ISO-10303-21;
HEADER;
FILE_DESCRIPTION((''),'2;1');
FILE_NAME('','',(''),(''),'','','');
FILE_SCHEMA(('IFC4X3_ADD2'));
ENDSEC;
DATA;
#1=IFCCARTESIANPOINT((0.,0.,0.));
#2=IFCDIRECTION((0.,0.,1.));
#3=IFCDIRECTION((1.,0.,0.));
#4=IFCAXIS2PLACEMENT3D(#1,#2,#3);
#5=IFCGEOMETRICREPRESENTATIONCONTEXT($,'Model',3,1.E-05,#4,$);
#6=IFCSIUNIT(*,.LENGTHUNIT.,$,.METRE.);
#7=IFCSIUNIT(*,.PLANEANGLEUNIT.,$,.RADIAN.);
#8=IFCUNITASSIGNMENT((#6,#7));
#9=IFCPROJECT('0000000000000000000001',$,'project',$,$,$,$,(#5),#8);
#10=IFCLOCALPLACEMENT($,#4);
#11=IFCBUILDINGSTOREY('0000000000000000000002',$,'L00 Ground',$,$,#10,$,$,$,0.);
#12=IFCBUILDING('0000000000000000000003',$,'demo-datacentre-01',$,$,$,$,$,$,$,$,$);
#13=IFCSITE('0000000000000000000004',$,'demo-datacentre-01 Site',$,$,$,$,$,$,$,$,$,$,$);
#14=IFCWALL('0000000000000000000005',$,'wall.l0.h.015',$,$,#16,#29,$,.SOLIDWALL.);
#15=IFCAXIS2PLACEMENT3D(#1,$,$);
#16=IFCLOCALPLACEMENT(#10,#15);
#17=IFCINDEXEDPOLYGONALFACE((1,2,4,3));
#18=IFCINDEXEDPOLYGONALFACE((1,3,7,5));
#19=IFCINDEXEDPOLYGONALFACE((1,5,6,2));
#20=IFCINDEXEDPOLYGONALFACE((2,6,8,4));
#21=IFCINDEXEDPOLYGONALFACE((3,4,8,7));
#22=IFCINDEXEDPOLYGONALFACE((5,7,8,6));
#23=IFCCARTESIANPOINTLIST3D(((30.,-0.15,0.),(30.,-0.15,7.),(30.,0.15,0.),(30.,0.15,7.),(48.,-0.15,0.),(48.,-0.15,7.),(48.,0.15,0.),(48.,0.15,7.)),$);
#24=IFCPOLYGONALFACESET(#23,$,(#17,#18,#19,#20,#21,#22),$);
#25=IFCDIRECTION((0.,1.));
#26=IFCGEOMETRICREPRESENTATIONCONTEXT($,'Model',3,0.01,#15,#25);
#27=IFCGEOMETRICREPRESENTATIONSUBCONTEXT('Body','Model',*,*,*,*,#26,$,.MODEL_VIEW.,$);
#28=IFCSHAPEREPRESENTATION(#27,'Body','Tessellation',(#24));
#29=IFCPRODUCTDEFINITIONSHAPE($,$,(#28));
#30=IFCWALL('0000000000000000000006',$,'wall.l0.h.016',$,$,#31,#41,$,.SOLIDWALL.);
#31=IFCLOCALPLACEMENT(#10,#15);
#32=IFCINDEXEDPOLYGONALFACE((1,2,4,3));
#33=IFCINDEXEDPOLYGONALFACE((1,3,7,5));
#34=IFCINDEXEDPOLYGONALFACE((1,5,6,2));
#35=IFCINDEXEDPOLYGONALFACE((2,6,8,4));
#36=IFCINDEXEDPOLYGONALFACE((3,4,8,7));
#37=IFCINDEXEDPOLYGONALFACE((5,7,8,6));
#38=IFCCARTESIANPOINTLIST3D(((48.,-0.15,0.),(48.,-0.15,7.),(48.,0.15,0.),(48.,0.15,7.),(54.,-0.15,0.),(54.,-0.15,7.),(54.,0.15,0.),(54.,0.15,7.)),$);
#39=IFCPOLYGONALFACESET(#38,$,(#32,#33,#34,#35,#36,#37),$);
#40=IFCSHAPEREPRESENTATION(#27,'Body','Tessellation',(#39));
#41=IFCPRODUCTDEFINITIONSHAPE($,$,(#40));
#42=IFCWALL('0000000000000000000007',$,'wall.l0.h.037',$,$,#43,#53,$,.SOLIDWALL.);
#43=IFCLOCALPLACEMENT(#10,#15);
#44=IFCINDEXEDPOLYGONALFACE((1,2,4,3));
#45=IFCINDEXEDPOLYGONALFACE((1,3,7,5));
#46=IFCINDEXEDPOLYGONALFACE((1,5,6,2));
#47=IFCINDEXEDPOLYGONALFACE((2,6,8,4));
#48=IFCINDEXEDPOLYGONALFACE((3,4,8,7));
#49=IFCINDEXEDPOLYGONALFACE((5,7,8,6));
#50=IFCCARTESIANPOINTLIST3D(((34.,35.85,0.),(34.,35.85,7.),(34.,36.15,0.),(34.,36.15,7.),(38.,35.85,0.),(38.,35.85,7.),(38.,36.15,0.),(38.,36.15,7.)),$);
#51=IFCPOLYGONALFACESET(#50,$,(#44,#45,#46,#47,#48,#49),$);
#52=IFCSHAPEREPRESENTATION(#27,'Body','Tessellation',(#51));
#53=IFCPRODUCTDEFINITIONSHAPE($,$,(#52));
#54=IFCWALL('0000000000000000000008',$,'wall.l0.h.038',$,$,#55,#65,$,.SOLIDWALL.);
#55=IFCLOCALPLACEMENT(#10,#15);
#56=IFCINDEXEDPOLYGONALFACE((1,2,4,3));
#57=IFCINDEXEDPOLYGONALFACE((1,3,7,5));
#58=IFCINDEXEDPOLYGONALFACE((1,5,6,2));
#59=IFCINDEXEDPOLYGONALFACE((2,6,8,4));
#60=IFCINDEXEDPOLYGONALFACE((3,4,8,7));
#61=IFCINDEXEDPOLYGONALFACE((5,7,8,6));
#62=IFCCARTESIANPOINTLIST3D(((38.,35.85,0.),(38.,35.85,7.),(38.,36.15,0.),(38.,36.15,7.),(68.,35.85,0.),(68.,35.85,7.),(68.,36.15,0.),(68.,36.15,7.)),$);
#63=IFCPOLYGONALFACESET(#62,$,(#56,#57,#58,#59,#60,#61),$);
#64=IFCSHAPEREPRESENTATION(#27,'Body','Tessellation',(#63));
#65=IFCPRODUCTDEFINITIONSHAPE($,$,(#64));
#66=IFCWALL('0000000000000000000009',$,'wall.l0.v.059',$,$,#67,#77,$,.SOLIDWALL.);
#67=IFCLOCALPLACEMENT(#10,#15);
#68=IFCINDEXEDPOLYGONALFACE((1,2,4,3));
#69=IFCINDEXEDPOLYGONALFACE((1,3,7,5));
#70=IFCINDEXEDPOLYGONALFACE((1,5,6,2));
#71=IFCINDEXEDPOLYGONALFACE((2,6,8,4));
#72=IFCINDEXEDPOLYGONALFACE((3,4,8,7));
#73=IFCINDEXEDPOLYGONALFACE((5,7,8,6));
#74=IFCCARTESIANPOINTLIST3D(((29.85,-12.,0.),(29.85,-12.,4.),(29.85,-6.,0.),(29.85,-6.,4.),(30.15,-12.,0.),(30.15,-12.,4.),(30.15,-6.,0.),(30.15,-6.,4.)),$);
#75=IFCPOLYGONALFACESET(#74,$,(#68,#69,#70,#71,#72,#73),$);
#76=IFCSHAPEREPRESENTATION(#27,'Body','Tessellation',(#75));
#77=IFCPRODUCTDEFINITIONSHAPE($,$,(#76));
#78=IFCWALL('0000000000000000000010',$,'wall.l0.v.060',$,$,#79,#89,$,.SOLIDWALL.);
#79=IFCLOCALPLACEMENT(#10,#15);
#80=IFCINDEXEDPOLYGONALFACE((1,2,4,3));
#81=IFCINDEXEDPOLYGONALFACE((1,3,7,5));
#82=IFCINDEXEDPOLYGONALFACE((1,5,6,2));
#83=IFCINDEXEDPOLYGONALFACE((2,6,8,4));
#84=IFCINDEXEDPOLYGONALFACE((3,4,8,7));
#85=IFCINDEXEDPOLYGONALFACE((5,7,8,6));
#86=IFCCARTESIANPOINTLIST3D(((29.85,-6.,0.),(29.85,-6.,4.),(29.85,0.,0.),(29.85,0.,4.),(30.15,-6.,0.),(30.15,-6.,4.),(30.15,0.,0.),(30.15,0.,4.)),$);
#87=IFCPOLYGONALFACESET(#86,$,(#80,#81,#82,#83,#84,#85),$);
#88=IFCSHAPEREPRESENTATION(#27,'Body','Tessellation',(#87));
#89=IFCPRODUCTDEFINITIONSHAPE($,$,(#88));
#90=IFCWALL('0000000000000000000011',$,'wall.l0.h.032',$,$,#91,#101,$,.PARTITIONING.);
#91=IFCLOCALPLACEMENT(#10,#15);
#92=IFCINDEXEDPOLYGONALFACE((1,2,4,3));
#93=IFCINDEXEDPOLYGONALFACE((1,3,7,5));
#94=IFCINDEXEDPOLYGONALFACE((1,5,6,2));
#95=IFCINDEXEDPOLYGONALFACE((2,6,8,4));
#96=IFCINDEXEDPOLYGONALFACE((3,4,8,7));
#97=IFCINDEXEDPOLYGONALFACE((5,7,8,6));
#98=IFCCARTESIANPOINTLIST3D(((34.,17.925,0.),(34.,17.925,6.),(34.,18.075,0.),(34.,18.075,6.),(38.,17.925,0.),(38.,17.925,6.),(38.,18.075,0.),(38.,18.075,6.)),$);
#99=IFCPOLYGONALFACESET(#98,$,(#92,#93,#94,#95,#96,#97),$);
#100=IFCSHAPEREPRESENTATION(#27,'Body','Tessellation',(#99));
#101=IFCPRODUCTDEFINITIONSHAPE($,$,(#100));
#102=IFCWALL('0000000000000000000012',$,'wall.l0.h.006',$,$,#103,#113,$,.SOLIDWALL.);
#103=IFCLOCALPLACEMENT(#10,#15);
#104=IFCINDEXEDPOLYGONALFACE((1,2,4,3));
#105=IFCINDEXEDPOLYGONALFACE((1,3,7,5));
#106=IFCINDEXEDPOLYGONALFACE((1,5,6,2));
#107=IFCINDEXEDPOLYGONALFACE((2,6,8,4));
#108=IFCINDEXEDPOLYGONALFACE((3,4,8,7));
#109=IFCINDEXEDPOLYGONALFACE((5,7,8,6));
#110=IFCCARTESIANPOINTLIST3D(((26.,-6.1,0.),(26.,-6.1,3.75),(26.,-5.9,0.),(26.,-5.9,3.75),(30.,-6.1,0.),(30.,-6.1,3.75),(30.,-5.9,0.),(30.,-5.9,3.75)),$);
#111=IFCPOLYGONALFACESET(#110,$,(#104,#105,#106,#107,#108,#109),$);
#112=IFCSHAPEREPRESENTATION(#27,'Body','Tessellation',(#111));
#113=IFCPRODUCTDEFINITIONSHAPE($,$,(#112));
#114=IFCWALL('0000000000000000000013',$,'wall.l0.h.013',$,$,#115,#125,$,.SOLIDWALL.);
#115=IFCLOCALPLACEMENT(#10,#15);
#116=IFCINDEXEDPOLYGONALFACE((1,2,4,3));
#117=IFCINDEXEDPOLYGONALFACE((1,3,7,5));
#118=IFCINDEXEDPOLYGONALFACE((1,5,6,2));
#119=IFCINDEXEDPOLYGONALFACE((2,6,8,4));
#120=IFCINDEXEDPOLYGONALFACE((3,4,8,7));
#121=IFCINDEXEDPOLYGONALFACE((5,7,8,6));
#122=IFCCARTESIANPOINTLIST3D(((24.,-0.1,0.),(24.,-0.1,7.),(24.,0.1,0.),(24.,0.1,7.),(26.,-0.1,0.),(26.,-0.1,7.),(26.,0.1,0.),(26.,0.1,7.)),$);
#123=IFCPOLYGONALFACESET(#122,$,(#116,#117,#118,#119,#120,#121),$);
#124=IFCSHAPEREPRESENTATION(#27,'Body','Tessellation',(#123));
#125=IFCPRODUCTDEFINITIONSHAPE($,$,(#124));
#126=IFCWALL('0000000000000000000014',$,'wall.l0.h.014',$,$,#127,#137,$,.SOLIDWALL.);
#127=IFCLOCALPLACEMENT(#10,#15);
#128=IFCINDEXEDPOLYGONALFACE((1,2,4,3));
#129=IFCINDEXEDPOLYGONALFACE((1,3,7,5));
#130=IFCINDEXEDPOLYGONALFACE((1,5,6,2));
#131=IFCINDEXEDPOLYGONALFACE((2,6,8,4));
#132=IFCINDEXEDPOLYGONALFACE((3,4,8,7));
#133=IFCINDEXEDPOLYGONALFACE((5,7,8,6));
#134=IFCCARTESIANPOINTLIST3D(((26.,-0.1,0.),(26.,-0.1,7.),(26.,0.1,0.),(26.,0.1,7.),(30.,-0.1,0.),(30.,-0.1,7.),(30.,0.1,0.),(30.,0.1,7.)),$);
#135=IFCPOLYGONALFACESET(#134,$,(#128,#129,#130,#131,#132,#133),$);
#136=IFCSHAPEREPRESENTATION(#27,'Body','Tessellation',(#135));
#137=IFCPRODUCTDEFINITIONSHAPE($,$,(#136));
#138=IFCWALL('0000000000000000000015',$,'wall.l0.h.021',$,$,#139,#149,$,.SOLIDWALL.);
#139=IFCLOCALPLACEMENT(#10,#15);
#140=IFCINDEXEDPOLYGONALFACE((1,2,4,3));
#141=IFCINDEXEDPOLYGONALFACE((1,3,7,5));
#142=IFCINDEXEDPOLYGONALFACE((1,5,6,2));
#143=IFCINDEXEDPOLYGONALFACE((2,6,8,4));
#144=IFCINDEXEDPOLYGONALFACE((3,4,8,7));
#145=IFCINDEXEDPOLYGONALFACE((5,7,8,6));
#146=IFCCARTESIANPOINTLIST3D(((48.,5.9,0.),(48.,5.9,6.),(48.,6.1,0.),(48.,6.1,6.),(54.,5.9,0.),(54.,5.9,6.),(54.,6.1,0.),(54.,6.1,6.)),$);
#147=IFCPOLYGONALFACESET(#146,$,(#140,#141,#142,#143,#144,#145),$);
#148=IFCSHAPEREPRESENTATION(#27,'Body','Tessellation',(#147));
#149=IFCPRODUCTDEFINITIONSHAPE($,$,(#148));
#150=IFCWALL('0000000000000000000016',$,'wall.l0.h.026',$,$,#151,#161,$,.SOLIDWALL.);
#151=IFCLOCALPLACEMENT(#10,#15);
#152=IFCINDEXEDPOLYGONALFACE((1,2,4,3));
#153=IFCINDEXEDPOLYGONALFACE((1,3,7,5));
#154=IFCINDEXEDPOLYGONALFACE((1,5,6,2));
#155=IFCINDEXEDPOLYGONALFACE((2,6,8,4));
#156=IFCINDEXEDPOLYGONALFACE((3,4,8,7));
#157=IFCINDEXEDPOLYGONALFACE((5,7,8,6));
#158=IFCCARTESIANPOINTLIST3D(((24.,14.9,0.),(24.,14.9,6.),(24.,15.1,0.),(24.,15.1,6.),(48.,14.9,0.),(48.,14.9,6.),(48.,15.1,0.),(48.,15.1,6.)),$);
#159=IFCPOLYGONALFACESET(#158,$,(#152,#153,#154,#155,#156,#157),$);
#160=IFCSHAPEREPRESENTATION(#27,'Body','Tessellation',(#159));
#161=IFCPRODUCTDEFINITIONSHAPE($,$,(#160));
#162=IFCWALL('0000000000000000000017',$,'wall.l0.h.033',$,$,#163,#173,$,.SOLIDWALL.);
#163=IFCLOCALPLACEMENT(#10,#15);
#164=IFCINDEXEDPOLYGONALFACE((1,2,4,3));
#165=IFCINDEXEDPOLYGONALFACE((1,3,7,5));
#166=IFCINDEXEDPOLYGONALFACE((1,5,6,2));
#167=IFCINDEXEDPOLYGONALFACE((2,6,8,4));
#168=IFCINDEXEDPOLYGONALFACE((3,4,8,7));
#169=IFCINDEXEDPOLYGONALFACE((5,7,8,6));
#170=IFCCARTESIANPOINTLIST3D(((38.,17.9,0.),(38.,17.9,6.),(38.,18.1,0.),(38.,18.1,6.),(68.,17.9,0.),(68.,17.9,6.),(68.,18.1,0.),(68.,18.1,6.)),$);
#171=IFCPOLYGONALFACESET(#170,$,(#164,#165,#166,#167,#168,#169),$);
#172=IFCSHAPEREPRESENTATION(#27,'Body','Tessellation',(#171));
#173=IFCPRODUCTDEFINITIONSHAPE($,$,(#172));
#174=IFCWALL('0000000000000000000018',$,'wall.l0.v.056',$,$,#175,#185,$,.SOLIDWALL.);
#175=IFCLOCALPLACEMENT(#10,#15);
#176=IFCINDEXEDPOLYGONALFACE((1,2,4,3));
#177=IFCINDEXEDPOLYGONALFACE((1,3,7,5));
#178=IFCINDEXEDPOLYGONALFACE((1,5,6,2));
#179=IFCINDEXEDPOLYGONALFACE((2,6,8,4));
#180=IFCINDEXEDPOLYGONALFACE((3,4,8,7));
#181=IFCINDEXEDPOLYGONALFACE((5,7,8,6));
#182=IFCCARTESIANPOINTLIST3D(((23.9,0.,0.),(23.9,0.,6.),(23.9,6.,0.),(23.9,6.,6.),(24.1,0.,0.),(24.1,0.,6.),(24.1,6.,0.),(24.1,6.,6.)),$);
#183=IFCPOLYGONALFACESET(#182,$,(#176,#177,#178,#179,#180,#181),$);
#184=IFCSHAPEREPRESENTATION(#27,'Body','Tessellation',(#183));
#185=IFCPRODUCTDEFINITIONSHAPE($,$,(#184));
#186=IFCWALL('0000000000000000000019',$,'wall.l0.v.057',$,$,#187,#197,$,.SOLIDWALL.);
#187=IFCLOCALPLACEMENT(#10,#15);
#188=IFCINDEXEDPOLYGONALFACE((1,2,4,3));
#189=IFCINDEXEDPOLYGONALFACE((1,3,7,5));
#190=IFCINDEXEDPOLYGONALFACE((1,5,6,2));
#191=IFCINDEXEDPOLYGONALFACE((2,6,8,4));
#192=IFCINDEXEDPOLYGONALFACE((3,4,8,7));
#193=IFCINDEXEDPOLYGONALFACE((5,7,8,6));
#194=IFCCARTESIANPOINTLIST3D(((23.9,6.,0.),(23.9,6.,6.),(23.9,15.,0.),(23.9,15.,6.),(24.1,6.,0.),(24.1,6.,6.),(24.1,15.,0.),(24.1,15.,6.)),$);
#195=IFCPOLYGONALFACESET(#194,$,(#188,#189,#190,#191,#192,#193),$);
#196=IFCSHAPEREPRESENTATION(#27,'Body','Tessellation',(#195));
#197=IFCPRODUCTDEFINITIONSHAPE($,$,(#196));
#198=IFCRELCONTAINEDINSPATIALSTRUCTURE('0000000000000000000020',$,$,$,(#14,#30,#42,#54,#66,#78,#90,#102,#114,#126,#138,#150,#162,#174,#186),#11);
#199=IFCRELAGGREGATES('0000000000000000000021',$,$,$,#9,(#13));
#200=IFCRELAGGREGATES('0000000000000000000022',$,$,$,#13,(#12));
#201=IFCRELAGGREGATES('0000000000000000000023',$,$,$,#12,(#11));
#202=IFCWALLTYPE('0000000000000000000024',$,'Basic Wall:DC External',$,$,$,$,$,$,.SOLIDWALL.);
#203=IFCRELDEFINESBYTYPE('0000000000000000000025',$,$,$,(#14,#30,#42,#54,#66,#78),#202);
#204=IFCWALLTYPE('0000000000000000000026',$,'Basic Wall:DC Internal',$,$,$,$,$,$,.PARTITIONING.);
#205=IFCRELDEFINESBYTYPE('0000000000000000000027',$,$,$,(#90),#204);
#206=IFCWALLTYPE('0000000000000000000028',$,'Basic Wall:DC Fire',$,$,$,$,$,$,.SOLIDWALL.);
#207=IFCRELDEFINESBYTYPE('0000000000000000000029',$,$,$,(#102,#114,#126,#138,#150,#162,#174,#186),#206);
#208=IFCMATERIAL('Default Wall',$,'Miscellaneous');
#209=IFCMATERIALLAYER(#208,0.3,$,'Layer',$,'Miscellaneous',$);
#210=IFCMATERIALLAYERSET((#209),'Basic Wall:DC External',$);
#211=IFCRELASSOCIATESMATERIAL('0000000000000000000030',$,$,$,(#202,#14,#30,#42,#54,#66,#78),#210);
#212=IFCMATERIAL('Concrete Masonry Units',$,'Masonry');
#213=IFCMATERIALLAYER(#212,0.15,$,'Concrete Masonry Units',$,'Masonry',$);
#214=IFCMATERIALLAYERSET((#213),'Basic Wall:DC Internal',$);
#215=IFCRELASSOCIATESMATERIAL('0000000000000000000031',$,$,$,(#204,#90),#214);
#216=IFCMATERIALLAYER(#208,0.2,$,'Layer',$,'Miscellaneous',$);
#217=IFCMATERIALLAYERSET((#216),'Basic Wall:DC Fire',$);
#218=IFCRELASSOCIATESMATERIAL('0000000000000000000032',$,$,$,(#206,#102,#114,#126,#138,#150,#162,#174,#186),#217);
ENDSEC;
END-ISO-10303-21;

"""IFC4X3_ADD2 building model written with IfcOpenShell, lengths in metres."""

from ifc_helpers import new_model, si_unit, direction, frame, frame_2d, origin, origin_with_axes, place, context, subcontext, project, spatial, rectangle, extrude, material, layer, layer_set, type_object, element, save


model = new_model("IFC4X3_ADD2")

# Units and contexts
model_context_1 = context("Model", 3, precision=0.01, world=origin(), true_north=direction((0.0, 1.0)))
model_context_2 = context("Model", 3, precision=1e-05, world=origin_with_axes())
body_context = subcontext(model_context_1, "Body", "Model", "MODEL_VIEW")
ifc_project = project(units=[si_unit("LENGTHUNIT", "METRE"), si_unit("PLANEANGLEUNIT", "RADIAN")], contexts=[model_context_2])

# Site, building, storey
site = spatial("IfcSite", under=ifc_project, Name="demo-datacentre-01 Site")
building = spatial("IfcBuilding", under=site, Name="demo-datacentre-01")
storey_placement = place(None, origin_with_axes())
storey = spatial("IfcBuildingStorey", under=building, at=storey_placement, Name="L00 Ground", Elevation=0.0)

# Walls
ifc_material_1 = material(Name="Default Wall", Category="Miscellaneous")
ifc_layer_1 = layer(ifc_material_1, 0.3, Name="Layer", Category="Miscellaneous")
ifc_layer_set_1 = layer_set([ifc_layer_1], Name="Basic Wall:DC External")
wall_type_1 = type_object("IfcWallType", Name="Basic Wall:DC External", PredefinedType="SOLIDWALL", material=ifc_layer_set_1)
placement_1 = place(None, origin())
placement_2 = place(placement_1, origin())
placement_3 = place(placement_2, origin())
wall_1_placement = place(placement_3, frame((30.0, 0.0, 0.0)))
element("IfcWall", 1, at=wall_1_placement, inside=storey, type_object=wall_type_1, material=ifc_layer_set_1, Name="wall.l0.h.015", PredefinedType="SOLIDWALL", context=body_context, shape_type="SweptSolid", body=[
    extrude(rectangle(XDim=18.0, YDim=0.3, at=frame_2d((9.0, 0.0), x_axis=(-1.0, 0.0))), origin(), (0.0, 0.0, 1.0), 7.0),
])
wall_2_placement = place(placement_3, frame((48.0, 0.0, 0.0)))
element("IfcWall", 2, at=wall_2_placement, inside=storey, type_object=wall_type_1, material=ifc_layer_set_1, Name="wall.l0.h.016", PredefinedType="SOLIDWALL", context=body_context, shape_type="SweptSolid", body=[
    extrude(rectangle(XDim=6.0, YDim=0.3, at=frame_2d((3.0, 0.0), x_axis=(-1.0, 0.0))), origin(), (0.0, 0.0, 1.0), 7.0),
])
wall_3_placement = place(placement_3, frame((34.0, 36.0, 0.0)))
element("IfcWall", 3, at=wall_3_placement, inside=storey, type_object=wall_type_1, material=ifc_layer_set_1, Name="wall.l0.h.037", PredefinedType="SOLIDWALL", context=body_context, shape_type="SweptSolid", body=[
    extrude(rectangle(XDim=4.0, YDim=0.3, at=frame_2d((2.0, 0.0), x_axis=(-1.0, 0.0))), origin(), (0.0, 0.0, 1.0), 7.0),
])
wall_4_placement = place(placement_3, frame((38.0, 36.0, 0.0)))
element("IfcWall", 4, at=wall_4_placement, inside=storey, type_object=wall_type_1, material=ifc_layer_set_1, Name="wall.l0.h.038", PredefinedType="SOLIDWALL", context=body_context, shape_type="SweptSolid", body=[
    extrude(rectangle(XDim=30.0, YDim=0.3, at=frame_2d((15.0, 0.0), x_axis=(-1.0, 0.0))), origin(), (0.0, 0.0, 1.0), 7.0),
])
for number, where, z_axis, x_axis, name in (
    (5, (30.0, -12.0, 0.0), (0.0, 0.0, 1.0), (0.0, 1.0, 0.0), "wall.l0.v.059"),
    (6, (30.0, -6.0, 0.0), (0.0, 0.0, 1.0), (0.0, 1.0, 0.0), "wall.l0.v.060"),
):
    element("IfcWall", number, at=place(placement_3, frame(where, z_axis=z_axis, x_axis=x_axis)), inside=storey, type_object=wall_type_1, material=ifc_layer_set_1, Name=name, PredefinedType="SOLIDWALL", context=body_context, shape_type="SweptSolid", body=[
        extrude(rectangle(XDim=6.0, YDim=0.3, at=frame_2d((3.0, 0.0), x_axis=(-1.0, 0.0))), origin(), (0.0, 0.0, 1.0), 4.0),
    ])
ifc_material_2 = material(Name="Concrete Masonry Units", Category="Masonry")
ifc_layer_2 = layer(ifc_material_2, 0.15, Name="Concrete Masonry Units", Category="Masonry")
ifc_layer_set_2 = layer_set([ifc_layer_2], Name="Basic Wall:DC Internal")
wall_type_2 = type_object("IfcWallType", Name="Basic Wall:DC Internal", PredefinedType="PARTITIONING", material=ifc_layer_set_2)
wall_5_placement = place(placement_3, frame((34.0, 18.0, 0.0)))
element("IfcWall", 7, at=wall_5_placement, inside=storey, type_object=wall_type_2, material=ifc_layer_set_2, Name="wall.l0.h.032", PredefinedType="PARTITIONING", context=body_context, shape_type="SweptSolid", body=[
    extrude(rectangle(XDim=4.0, YDim=0.15, at=frame_2d((2.0, 0.0), x_axis=(-1.0, 0.0))), origin(), (0.0, 0.0, 1.0), 6.0),
])
ifc_layer_3 = layer(ifc_material_1, 0.2, Name="Layer", Category="Miscellaneous")
ifc_layer_set_3 = layer_set([ifc_layer_3], Name="Basic Wall:DC Fire")
wall_type_3 = type_object("IfcWallType", Name="Basic Wall:DC Fire", PredefinedType="SOLIDWALL", material=ifc_layer_set_3)
wall_6_placement = place(placement_3, frame((26.0, -6.0, 0.0)))
element("IfcWall", 8, at=wall_6_placement, inside=storey, type_object=wall_type_3, material=ifc_layer_set_3, Name="wall.l0.h.006", PredefinedType="SOLIDWALL", context=body_context, shape_type="SweptSolid", body=[
    extrude(rectangle(XDim=4.0, YDim=0.2, at=frame_2d((2.0, 0.0), x_axis=(-1.0, 0.0))), origin(), (0.0, 0.0, 1.0), 3.75),
])
wall_7_placement = place(placement_3, frame((24.0, 0.0, 0.0)))
element("IfcWall", 9, at=wall_7_placement, inside=storey, type_object=wall_type_3, material=ifc_layer_set_3, Name="wall.l0.h.013", PredefinedType="SOLIDWALL", context=body_context, shape_type="SweptSolid", body=[
    extrude(rectangle(XDim=2.0, YDim=0.2, at=frame_2d((1.0, 0.0), x_axis=(-1.0, 0.0))), origin(), (0.0, 0.0, 1.0), 7.0),
])
wall_8_placement = place(placement_3, frame((26.0, 0.0, 0.0)))
element("IfcWall", 10, at=wall_8_placement, inside=storey, type_object=wall_type_3, material=ifc_layer_set_3, Name="wall.l0.h.014", PredefinedType="SOLIDWALL", context=body_context, shape_type="SweptSolid", body=[
    extrude(rectangle(XDim=4.0, YDim=0.2, at=frame_2d((2.0, 0.0), x_axis=(-1.0, 0.0))), origin(), (0.0, 0.0, 1.0), 7.0),
])
wall_9_placement = place(placement_3, frame((48.0, 6.0, 0.0)))
element("IfcWall", 11, at=wall_9_placement, inside=storey, type_object=wall_type_3, material=ifc_layer_set_3, Name="wall.l0.h.021", PredefinedType="SOLIDWALL", context=body_context, shape_type="SweptSolid", body=[
    extrude(rectangle(XDim=6.0, YDim=0.2, at=frame_2d((3.0, 0.0), x_axis=(-1.0, 0.0))), origin(), (0.0, 0.0, 1.0), 6.0),
])
wall_10_placement = place(placement_3, frame((24.0, 15.0, 0.0)))
element("IfcWall", 12, at=wall_10_placement, inside=storey, type_object=wall_type_3, material=ifc_layer_set_3, Name="wall.l0.h.026", PredefinedType="SOLIDWALL", context=body_context, shape_type="SweptSolid", body=[
    extrude(rectangle(XDim=24.0, YDim=0.2, at=frame_2d((12.0, 0.0), x_axis=(-1.0, 0.0))), origin(), (0.0, 0.0, 1.0), 6.0),
])
wall_11_placement = place(placement_3, frame((38.0, 18.0, 0.0)))
element("IfcWall", 13, at=wall_11_placement, inside=storey, type_object=wall_type_3, material=ifc_layer_set_3, Name="wall.l0.h.033", PredefinedType="SOLIDWALL", context=body_context, shape_type="SweptSolid", body=[
    extrude(rectangle(XDim=30.0, YDim=0.2, at=frame_2d((15.0, 0.0), x_axis=(-1.0, 0.0))), origin(), (0.0, 0.0, 1.0), 6.0),
])
wall_12_placement = place(placement_3, frame((24.0, 0.0, 0.0), z_axis=(0.0, 0.0, 1.0), x_axis=(0.0, 1.0, 0.0)))
element("IfcWall", 14, at=wall_12_placement, inside=storey, type_object=wall_type_3, material=ifc_layer_set_3, Name="wall.l0.v.056", PredefinedType="SOLIDWALL", context=body_context, shape_type="SweptSolid", body=[
    extrude(rectangle(XDim=6.0, YDim=0.2, at=frame_2d((3.0, 0.0), x_axis=(-1.0, 0.0))), origin(), (0.0, 0.0, 1.0), 6.0),
])
wall_13_placement = place(placement_3, frame((24.0, 6.0, 0.0), z_axis=(0.0, 0.0, 1.0), x_axis=(0.0, 1.0, 0.0)))
element("IfcWall", 15, at=wall_13_placement, inside=storey, type_object=wall_type_3, material=ifc_layer_set_3, Name="wall.l0.v.057", PredefinedType="SOLIDWALL", context=body_context, shape_type="SweptSolid", body=[
    extrude(rectangle(XDim=9.0, YDim=0.2, at=frame_2d((4.5, 0.0), x_axis=(-1.0, 0.0))), origin(), (0.0, 0.0, 1.0), 6.0),
])

save(model, "model.ifc")
